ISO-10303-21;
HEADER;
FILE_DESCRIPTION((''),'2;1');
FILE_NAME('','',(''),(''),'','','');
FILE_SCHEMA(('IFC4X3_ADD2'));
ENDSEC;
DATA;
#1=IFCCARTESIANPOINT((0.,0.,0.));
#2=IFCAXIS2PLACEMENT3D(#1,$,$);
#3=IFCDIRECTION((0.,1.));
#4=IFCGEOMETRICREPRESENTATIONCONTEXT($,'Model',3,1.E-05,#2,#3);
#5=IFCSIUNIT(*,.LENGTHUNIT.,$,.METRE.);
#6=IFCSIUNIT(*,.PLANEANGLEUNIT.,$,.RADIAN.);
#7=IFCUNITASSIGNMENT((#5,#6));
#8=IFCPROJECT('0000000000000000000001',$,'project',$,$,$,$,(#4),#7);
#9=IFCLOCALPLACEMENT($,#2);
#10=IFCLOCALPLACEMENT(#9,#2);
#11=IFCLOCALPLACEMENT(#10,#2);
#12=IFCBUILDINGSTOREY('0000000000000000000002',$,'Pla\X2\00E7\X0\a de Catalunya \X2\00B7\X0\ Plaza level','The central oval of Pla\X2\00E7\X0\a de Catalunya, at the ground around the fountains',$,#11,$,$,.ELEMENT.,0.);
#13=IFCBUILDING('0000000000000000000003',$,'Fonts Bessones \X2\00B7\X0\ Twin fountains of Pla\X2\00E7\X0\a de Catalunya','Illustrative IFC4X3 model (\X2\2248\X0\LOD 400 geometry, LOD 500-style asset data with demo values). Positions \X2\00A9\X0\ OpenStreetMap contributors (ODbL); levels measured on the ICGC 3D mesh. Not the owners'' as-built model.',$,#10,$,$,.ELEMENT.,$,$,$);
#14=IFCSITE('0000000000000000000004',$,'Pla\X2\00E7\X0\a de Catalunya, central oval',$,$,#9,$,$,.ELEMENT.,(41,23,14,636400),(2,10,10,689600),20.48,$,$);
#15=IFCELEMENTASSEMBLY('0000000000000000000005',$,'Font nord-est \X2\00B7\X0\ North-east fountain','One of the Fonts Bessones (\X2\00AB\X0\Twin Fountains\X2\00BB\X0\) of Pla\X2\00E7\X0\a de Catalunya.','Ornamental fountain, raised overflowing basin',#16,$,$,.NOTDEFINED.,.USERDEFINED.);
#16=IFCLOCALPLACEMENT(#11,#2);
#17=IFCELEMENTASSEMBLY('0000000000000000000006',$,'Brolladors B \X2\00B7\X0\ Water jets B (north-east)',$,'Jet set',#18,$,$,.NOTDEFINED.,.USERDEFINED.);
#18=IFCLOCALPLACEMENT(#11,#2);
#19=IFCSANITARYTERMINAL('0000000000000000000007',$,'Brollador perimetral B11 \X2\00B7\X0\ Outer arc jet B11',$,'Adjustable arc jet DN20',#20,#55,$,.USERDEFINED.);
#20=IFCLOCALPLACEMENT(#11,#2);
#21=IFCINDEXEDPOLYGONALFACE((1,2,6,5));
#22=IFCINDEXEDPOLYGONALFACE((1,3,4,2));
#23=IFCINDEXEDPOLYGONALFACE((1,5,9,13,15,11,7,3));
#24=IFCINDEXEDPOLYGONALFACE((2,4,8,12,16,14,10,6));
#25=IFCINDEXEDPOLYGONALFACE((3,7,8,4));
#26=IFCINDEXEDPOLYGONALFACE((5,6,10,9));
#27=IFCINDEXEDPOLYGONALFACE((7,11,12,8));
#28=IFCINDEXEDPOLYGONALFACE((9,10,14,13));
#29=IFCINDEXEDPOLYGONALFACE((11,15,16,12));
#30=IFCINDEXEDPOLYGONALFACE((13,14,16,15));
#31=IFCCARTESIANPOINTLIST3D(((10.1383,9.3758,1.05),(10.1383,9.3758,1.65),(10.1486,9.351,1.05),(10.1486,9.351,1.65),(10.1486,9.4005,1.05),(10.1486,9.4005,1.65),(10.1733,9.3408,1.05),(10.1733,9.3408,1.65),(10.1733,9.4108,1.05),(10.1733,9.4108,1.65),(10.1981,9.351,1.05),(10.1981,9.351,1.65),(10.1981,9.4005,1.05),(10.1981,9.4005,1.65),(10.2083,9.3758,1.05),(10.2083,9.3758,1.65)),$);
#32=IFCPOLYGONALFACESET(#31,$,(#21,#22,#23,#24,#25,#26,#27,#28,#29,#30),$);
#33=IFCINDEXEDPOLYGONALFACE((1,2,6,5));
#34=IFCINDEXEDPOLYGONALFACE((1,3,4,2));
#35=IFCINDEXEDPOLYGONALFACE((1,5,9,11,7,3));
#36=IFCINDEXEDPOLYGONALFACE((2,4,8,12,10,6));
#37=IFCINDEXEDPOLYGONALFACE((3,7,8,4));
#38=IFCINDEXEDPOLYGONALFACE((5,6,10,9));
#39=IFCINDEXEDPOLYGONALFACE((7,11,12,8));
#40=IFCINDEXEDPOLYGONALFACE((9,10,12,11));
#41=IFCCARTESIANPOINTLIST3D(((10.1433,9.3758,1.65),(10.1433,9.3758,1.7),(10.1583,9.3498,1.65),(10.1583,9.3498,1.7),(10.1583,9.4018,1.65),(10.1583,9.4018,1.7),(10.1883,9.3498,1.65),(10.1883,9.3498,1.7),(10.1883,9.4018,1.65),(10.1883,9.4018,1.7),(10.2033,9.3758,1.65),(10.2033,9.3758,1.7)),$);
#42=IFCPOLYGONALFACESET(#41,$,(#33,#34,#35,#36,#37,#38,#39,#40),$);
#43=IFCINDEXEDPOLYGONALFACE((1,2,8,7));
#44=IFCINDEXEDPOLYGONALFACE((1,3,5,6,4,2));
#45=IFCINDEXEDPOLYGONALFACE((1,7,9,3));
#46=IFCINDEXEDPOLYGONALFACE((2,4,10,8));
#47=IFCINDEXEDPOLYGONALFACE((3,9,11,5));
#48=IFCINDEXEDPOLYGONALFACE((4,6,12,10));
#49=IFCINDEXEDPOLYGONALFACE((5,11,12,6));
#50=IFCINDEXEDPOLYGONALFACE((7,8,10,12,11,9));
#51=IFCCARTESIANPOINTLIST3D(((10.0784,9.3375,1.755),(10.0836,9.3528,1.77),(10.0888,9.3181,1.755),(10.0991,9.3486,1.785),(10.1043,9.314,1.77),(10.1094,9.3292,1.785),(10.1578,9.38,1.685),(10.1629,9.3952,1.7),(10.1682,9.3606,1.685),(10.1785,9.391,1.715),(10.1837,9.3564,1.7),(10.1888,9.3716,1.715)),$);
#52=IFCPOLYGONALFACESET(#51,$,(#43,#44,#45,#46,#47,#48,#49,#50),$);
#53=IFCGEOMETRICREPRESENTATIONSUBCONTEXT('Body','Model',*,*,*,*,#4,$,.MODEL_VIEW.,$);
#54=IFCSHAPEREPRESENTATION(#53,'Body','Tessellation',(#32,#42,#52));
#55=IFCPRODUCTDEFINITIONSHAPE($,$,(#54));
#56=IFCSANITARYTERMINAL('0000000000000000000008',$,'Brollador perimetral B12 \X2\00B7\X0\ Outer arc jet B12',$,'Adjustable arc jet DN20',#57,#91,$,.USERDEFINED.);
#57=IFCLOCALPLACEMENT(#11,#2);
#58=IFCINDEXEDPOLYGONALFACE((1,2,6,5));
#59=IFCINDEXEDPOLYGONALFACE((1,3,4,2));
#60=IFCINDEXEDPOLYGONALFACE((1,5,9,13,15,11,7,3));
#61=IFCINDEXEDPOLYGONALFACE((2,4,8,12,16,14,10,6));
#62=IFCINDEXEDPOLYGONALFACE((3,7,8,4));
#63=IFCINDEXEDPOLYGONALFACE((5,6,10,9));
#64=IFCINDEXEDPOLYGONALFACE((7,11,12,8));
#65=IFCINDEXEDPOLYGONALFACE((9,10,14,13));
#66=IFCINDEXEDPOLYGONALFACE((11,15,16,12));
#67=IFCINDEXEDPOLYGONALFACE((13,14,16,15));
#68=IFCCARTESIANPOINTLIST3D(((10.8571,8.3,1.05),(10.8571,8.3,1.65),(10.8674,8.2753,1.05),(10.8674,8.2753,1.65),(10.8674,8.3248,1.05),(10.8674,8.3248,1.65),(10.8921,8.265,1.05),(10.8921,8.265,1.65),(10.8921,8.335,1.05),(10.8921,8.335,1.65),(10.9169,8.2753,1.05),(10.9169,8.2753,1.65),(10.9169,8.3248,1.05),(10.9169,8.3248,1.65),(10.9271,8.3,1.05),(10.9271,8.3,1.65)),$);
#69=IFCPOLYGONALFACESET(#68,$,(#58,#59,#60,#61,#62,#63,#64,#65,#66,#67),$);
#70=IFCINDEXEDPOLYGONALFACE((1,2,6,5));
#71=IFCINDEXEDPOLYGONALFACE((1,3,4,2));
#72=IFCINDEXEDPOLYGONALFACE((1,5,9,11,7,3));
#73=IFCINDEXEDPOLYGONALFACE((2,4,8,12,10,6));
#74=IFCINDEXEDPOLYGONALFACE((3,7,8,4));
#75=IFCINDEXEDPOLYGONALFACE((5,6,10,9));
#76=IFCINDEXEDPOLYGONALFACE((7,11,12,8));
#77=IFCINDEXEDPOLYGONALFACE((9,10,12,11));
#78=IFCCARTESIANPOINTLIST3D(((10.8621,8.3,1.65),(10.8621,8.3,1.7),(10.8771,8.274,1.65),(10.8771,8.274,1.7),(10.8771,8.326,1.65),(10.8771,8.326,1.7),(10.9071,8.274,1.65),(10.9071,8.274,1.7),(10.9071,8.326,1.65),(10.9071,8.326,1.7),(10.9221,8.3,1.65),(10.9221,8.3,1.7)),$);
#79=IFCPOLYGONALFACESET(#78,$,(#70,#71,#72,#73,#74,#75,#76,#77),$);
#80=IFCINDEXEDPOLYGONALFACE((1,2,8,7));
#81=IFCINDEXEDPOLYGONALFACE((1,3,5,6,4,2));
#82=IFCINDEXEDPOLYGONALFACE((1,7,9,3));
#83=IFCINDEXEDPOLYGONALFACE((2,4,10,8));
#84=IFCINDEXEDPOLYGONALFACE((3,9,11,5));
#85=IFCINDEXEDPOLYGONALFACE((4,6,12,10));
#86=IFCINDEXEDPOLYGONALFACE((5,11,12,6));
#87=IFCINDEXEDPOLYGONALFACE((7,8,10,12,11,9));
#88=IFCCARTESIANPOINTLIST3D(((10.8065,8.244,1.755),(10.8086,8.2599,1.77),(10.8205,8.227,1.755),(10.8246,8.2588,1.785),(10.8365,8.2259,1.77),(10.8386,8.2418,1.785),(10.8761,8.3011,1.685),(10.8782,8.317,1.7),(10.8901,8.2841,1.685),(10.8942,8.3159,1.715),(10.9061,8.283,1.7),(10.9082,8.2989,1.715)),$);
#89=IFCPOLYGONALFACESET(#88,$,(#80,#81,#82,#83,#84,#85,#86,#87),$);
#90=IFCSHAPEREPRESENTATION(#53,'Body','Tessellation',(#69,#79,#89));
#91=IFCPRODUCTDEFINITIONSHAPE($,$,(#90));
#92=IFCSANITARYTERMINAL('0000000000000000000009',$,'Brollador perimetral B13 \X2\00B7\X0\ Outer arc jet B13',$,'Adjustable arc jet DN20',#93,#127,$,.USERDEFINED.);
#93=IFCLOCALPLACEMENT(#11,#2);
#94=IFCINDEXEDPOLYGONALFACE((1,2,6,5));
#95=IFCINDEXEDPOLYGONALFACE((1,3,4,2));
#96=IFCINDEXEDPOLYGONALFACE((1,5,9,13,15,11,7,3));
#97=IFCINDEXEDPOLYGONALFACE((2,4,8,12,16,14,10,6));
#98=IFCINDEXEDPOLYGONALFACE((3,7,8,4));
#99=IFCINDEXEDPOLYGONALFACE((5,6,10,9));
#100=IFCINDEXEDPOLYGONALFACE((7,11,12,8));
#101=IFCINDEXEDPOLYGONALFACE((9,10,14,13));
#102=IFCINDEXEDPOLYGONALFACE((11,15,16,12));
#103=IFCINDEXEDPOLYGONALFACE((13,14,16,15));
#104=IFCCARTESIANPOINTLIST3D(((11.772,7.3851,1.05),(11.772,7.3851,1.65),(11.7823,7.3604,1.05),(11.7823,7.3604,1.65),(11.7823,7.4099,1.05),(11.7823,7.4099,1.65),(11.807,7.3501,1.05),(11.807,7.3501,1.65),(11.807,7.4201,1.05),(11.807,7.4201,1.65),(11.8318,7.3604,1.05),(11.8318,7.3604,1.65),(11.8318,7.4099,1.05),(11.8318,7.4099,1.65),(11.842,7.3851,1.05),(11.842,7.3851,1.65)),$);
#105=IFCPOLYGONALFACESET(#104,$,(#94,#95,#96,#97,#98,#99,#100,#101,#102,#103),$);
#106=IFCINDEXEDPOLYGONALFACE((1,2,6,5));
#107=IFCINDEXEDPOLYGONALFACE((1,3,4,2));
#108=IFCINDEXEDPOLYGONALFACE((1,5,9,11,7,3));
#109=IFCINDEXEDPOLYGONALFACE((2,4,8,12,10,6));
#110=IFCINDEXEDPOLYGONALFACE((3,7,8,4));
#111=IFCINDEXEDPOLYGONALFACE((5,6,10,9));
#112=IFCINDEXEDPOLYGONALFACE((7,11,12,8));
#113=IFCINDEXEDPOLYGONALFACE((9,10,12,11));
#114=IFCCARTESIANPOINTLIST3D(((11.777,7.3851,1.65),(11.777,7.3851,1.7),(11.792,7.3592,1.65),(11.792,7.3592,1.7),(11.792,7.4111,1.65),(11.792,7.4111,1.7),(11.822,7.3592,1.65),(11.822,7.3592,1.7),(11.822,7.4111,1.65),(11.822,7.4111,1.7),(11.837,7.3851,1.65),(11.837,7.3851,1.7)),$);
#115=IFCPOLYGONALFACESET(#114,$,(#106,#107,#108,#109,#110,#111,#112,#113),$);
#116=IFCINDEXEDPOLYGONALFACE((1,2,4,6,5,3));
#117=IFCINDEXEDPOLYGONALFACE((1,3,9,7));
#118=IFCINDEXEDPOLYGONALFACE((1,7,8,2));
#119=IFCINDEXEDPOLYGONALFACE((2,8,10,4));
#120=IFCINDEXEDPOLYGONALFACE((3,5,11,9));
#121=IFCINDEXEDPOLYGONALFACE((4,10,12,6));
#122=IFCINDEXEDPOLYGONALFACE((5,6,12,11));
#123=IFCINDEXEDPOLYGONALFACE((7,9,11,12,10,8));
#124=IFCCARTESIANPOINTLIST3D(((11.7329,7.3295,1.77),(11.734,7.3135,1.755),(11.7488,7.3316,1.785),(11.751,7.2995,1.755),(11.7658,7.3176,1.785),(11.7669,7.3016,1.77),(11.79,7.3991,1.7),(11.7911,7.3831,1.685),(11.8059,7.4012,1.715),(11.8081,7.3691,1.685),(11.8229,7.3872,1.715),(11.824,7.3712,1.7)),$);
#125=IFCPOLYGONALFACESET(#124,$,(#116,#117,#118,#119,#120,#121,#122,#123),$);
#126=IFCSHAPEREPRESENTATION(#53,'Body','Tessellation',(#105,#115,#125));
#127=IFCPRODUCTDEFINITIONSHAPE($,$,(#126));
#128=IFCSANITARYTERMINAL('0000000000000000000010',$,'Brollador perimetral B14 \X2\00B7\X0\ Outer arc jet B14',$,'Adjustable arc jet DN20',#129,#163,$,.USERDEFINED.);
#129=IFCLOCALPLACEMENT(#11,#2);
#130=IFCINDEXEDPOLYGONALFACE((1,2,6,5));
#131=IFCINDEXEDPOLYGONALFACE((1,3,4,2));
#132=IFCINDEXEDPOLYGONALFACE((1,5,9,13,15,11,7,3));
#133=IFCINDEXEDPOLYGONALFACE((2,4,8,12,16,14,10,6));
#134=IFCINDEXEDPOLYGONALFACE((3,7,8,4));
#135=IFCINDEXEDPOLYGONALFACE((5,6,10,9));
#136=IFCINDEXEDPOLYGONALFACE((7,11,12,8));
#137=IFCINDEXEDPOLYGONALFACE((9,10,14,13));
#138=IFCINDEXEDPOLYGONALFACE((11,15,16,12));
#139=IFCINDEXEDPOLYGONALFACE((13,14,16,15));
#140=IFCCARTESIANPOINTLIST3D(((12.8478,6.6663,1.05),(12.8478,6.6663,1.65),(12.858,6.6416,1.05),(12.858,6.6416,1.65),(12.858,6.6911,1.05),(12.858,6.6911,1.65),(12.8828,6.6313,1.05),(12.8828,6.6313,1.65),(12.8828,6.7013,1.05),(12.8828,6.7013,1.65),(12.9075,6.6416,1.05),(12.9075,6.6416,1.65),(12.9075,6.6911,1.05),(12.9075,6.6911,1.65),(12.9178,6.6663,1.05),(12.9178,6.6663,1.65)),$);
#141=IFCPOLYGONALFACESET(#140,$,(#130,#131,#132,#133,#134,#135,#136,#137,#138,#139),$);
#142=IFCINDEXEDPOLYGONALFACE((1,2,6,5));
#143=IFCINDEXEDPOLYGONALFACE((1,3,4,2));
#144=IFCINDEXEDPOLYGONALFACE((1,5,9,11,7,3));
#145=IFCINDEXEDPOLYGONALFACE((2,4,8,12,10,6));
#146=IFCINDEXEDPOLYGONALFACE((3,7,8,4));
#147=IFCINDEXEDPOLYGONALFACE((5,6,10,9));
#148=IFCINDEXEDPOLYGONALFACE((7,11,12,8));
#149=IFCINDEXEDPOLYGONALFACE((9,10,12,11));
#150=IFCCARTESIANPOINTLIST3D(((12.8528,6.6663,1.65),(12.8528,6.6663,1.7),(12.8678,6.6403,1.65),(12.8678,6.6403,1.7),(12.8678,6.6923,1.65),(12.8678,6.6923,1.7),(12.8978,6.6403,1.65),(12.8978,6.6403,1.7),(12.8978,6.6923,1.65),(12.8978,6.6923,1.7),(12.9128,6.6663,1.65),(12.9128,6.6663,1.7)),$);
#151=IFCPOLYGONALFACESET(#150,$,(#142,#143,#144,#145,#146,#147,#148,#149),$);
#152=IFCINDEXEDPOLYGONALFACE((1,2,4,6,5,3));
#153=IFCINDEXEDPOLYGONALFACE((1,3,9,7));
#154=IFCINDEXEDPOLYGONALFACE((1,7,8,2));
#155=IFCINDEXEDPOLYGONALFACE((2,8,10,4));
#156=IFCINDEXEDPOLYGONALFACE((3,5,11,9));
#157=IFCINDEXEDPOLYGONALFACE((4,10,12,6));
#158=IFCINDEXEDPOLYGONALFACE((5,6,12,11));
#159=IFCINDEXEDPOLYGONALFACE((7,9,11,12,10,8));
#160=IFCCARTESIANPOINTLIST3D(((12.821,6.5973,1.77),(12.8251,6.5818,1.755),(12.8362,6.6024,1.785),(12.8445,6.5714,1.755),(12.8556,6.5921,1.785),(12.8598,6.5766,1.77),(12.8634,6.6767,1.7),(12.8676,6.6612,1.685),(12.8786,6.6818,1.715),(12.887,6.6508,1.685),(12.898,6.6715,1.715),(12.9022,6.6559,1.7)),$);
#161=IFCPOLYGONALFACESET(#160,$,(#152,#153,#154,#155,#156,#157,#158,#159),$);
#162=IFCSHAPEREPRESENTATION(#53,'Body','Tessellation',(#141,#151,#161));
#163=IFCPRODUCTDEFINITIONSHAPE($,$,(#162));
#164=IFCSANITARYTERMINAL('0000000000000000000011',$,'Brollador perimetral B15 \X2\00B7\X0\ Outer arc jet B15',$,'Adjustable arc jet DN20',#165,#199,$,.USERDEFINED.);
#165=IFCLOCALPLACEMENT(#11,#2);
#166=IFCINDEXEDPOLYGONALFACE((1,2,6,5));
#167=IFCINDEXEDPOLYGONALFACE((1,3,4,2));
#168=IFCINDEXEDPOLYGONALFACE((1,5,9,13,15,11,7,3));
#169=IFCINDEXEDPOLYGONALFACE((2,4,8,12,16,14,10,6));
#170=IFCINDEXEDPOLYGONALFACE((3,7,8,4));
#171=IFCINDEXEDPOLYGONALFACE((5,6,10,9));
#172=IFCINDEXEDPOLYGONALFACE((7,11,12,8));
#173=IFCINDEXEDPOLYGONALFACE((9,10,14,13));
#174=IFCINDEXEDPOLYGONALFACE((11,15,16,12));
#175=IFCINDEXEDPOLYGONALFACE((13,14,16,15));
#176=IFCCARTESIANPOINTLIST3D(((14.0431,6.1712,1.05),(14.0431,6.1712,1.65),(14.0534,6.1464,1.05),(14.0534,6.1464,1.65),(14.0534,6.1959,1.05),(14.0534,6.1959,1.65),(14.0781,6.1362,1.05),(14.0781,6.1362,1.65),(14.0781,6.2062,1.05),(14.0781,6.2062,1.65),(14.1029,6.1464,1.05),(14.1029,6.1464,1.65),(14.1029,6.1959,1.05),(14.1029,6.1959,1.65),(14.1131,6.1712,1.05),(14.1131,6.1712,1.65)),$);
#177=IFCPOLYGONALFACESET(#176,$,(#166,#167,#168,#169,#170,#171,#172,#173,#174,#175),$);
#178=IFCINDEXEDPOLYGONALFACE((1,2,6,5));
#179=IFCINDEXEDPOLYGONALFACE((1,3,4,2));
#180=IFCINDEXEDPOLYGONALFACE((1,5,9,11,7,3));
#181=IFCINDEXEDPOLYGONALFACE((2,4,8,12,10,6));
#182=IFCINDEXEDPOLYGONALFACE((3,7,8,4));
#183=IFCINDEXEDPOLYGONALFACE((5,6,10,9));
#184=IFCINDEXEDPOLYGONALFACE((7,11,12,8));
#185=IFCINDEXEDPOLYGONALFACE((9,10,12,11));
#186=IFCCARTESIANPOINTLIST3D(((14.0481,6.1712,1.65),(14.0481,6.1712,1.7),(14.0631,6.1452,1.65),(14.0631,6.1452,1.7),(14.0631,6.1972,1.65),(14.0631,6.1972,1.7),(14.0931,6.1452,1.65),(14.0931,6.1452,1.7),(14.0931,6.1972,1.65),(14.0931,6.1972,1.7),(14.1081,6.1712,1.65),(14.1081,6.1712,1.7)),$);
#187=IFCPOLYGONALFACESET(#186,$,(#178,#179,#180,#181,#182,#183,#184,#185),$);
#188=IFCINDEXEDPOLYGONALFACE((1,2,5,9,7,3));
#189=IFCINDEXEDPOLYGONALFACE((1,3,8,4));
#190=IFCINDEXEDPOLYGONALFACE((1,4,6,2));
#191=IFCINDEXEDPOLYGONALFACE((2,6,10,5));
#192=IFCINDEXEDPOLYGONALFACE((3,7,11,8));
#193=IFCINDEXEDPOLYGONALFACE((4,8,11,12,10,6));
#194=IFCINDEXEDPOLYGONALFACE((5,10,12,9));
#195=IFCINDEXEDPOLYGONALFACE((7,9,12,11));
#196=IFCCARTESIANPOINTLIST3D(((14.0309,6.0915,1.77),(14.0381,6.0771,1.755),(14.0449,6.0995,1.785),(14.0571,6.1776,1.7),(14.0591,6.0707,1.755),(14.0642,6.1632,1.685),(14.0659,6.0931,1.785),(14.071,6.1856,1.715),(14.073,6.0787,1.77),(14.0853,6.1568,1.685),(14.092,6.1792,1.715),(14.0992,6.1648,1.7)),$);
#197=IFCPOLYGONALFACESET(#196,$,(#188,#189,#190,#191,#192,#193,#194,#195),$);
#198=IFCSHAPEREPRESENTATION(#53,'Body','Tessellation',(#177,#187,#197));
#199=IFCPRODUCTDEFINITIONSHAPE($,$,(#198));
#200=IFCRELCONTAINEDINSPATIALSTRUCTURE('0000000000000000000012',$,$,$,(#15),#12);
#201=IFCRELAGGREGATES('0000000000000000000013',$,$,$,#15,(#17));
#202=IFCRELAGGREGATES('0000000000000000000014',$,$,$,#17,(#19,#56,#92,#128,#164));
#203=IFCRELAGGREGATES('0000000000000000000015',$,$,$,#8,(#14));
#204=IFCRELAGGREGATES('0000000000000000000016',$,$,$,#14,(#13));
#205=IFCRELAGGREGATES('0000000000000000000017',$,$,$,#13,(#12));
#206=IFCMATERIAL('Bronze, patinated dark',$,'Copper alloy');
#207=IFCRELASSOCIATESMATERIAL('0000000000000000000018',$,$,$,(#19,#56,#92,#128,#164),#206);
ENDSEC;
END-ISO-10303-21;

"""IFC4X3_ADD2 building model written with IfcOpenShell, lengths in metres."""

from ifc_helpers import new_model, si_unit, direction, frame, origin, place, context, subcontext, project, spatial, polyline, outline, extrude, material, element, aggregate, save


model = new_model("IFC4X3_ADD2")

# Units and contexts
model_context = context("Model", 3, precision=1e-05, world=origin(), true_north=direction((0.0, 1.0)))
body_context = subcontext(model_context, "Body", "Model", "MODEL_VIEW")
ifc_project = project(units=[si_unit("LENGTHUNIT", "METRE"), si_unit("PLANEANGLEUNIT", "RADIAN")], contexts=[model_context])

# Site, building, storey
site_placement = place(None, origin())
site = spatial("IfcSite", under=ifc_project, at=site_placement, Name="Plaça de Catalunya, central oval", CompositionType="ELEMENT", RefLatitude=(41, 23, 14, 636400), RefLongitude=(2, 10, 10, 689600), RefElevation=20.48)
building_placement = place(site_placement, origin())
building = spatial("IfcBuilding", under=site, at=building_placement, Name="Fonts Bessones · Twin fountains of Plaça de Catalunya", Description="Illustrative IFC4X3 model (≈LOD 400 geometry, LOD 500-style asset data with demo values). Positions © OpenStreetMap contributors (ODbL); levels measured on the ICGC 3D mesh. Not the owners' as-built model.", CompositionType="ELEMENT")
storey_placement = place(building_placement, origin())
storey = spatial("IfcBuildingStorey", under=building, at=storey_placement, Name="Plaça de Catalunya · Plaza level", Description="The central oval of Plaça de Catalunya, at the ground around the fountains", CompositionType="ELEMENT", Elevation=0.0)

# Element assemblies, sanitary terminals
assembly_1_placement = place(building_placement, origin())
assembly_1 = element("IfcElementAssembly", 1, at=assembly_1_placement, inside=storey, Name="Font nord-est · North-east fountain", Description="One of the Fonts Bessones («Twin Fountains») of Plaça de Catalunya.", ObjectType="Ornamental fountain, raised overflowing basin", AssemblyPlace="NOTDEFINED", PredefinedType="USERDEFINED")
assembly_2_placement = place(building_placement, origin())
assembly_2 = element("IfcElementAssembly", 2, at=assembly_2_placement, Name="Brolladors B · Water jets B (north-east)", ObjectType="Jet set", AssemblyPlace="NOTDEFINED", PredefinedType="USERDEFINED")
aggregate(assembly_1, [assembly_2])
ifc_material_1 = material(Name="Bronze, patinated dark", Category="Copper alloy")
sanitary_terminal_1_placement = place(building_placement, origin())
sanitary_terminal_1 = element("IfcSanitaryTerminal", 3, at=sanitary_terminal_1_placement, material=ifc_material_1, Name="Brollador perimetral B11 · Outer arc jet B11", ObjectType="Adjustable arc jet DN20", PredefinedType="USERDEFINED", context=body_context, shape_type="SweptSolid", body=[
    extrude(outline(polyline([(10.2083, 9.3758), (10.1981, 9.4005), (10.1733, 9.4108), (10.1486, 9.4005), (10.1383, 9.3758), (10.1486, 9.351), (10.1733, 9.3408), (10.1981, 9.351), (10.2083, 9.3758)])), frame((0.0, 0.0, 1.05)), (0.0, 0.0, 1.0), 0.6),
    extrude(outline(polyline([(10.2033, 9.3758), (10.1883, 9.4018), (10.1583, 9.4018), (10.1433, 9.3758), (10.1583, 9.3498), (10.1883, 9.3498), (10.2033, 9.3758)])), frame((0.0, 0.0, 1.65)), (0.0, 0.0, 1.0), 0.05),
    extrude(outline(polyline([(0.022, 0.0), (0.011, 0.0191), (-0.011, 0.0191), (-0.022, 0.0), (-0.011, -0.0191), (0.011, -0.0191), (0.022, 0.0)])), frame((10.1733, 9.3758, 1.7), z_axis=(-0.696147, -0.372098, 0.613941), x_axis=(-0.471397, 0.881921, 0.0)), (0.0, 0.0, 1.0), 0.114),
])
sanitary_terminal_2_placement = place(building_placement, origin())
sanitary_terminal_2 = element("IfcSanitaryTerminal", 4, at=sanitary_terminal_2_placement, material=ifc_material_1, Name="Brollador perimetral B12 · Outer arc jet B12", ObjectType="Adjustable arc jet DN20", PredefinedType="USERDEFINED", context=body_context, shape_type="SweptSolid", body=[
    extrude(outline(polyline([(10.9271, 8.3), (10.9169, 8.3248), (10.8921, 8.335), (10.8674, 8.3248), (10.8571, 8.3), (10.8674, 8.2753), (10.8921, 8.265), (10.9169, 8.2753), (10.9271, 8.3)])), frame((0.0, 0.0, 1.05)), (0.0, 0.0, 1.0), 0.6),
    extrude(outline(polyline([(10.9221, 8.3), (10.9071, 8.326), (10.8771, 8.326), (10.8621, 8.3), (10.8771, 8.274), (10.9071, 8.274), (10.9221, 8.3)])), frame((0.0, 0.0, 1.65)), (0.0, 0.0, 1.0), 0.05),
    extrude(outline(polyline([(0.022, 0.0), (0.011, 0.0191), (-0.011, 0.0191), (-0.022, 0.0), (-0.011, -0.0191), (0.011, -0.0191), (0.022, 0.0)])), frame((10.8921, 8.3, 1.7), z_axis=(-0.610178, -0.50076, 0.613941), x_axis=(-0.634393, 0.77301, 0.0)), (0.0, 0.0, 1.0), 0.114),
])
sanitary_terminal_3_placement = place(building_placement, origin())
sanitary_terminal_3 = element("IfcSanitaryTerminal", 5, at=sanitary_terminal_3_placement, material=ifc_material_1, Name="Brollador perimetral B13 · Outer arc jet B13", ObjectType="Adjustable arc jet DN20", PredefinedType="USERDEFINED", context=body_context, shape_type="SweptSolid", body=[
    extrude(outline(polyline([(11.842, 7.3851), (11.8318, 7.4099), (11.807, 7.4201), (11.7823, 7.4099), (11.772, 7.3851), (11.7823, 7.3604), (11.807, 7.3501), (11.8318, 7.3604), (11.842, 7.3851)])), frame((0.0, 0.0, 1.05)), (0.0, 0.0, 1.0), 0.6),
    extrude(outline(polyline([(11.837, 7.3851), (11.822, 7.4111), (11.792, 7.4111), (11.777, 7.3851), (11.792, 7.3592), (11.822, 7.3592), (11.837, 7.3851)])), frame((0.0, 0.0, 1.65)), (0.0, 0.0, 1.0), 0.05),
    extrude(outline(polyline([(0.022, 0.0), (0.011, 0.0191), (-0.011, 0.0191), (-0.022, 0.0), (-0.011, -0.0191), (0.011, -0.0191), (0.022, 0.0)])), frame((11.807, 7.3851, 1.7), z_axis=(-0.50076, -0.610178, 0.613941), x_axis=(-0.77301, 0.634393, 0.0)), (0.0, 0.0, 1.0), 0.114),
])
sanitary_terminal_4_placement = place(building_placement, origin())
sanitary_terminal_4 = element("IfcSanitaryTerminal", 6, at=sanitary_terminal_4_placement, material=ifc_material_1, Name="Brollador perimetral B14 · Outer arc jet B14", ObjectType="Adjustable arc jet DN20", PredefinedType="USERDEFINED", context=body_context, shape_type="SweptSolid", body=[
    extrude(outline(polyline([(12.9178, 6.6663), (12.9075, 6.6911), (12.8828, 6.7013), (12.858, 6.6911), (12.8478, 6.6663), (12.858, 6.6416), (12.8828, 6.6313), (12.9075, 6.6416), (12.9178, 6.6663)])), frame((0.0, 0.0, 1.05)), (0.0, 0.0, 1.0), 0.6),
    extrude(outline(polyline([(12.9128, 6.6663), (12.8978, 6.6923), (12.8678, 6.6923), (12.8528, 6.6663), (12.8678, 6.6403), (12.8978, 6.6403), (12.9128, 6.6663)])), frame((0.0, 0.0, 1.65)), (0.0, 0.0, 1.0), 0.05),
    extrude(outline(polyline([(0.022, 0.0), (0.011, 0.0191), (-0.011, 0.0191), (-0.022, 0.0), (-0.011, -0.0191), (0.011, -0.0191), (0.022, 0.0)])), frame((12.8828, 6.6663, 1.7), z_axis=(-0.372098, -0.696147, 0.613941), x_axis=(-0.881921, 0.471397, 0.0)), (0.0, 0.0, 1.0), 0.114),
])
sanitary_terminal_5_placement = place(building_placement, origin())
sanitary_terminal_5 = element("IfcSanitaryTerminal", 7, at=sanitary_terminal_5_placement, material=ifc_material_1, Name="Brollador perimetral B15 · Outer arc jet B15", ObjectType="Adjustable arc jet DN20", PredefinedType="USERDEFINED", context=body_context, shape_type="SweptSolid", body=[
    extrude(outline(polyline([(14.1131, 6.1712), (14.1029, 6.1959), (14.0781, 6.2062), (14.0534, 6.1959), (14.0431, 6.1712), (14.0534, 6.1464), (14.0781, 6.1362), (14.1029, 6.1464), (14.1131, 6.1712)])), frame((0.0, 0.0, 1.05)), (0.0, 0.0, 1.0), 0.6),
    extrude(outline(polyline([(14.1081, 6.1712), (14.0931, 6.1972), (14.0631, 6.1972), (14.0481, 6.1712), (14.0631, 6.1452), (14.0931, 6.1452), (14.1081, 6.1712)])), frame((0.0, 0.0, 1.65)), (0.0, 0.0, 1.0), 0.05),
    extrude(outline(polyline([(0.022, 0.0), (0.011, 0.0191), (-0.011, 0.0191), (-0.022, 0.0), (-0.011, -0.0191), (0.011, -0.0191), (0.022, 0.0)])), frame((14.0781, 6.1712, 1.7), z_axis=(-0.229137, -0.755363, 0.613941), x_axis=(-0.95694, 0.290285, 0.0)), (0.0, 0.0, 1.0), 0.114),
])
aggregate(assembly_2, [sanitary_terminal_1, sanitary_terminal_2, sanitary_terminal_3, sanitary_terminal_4, sanitary_terminal_5])

save(model, "model.ifc")
